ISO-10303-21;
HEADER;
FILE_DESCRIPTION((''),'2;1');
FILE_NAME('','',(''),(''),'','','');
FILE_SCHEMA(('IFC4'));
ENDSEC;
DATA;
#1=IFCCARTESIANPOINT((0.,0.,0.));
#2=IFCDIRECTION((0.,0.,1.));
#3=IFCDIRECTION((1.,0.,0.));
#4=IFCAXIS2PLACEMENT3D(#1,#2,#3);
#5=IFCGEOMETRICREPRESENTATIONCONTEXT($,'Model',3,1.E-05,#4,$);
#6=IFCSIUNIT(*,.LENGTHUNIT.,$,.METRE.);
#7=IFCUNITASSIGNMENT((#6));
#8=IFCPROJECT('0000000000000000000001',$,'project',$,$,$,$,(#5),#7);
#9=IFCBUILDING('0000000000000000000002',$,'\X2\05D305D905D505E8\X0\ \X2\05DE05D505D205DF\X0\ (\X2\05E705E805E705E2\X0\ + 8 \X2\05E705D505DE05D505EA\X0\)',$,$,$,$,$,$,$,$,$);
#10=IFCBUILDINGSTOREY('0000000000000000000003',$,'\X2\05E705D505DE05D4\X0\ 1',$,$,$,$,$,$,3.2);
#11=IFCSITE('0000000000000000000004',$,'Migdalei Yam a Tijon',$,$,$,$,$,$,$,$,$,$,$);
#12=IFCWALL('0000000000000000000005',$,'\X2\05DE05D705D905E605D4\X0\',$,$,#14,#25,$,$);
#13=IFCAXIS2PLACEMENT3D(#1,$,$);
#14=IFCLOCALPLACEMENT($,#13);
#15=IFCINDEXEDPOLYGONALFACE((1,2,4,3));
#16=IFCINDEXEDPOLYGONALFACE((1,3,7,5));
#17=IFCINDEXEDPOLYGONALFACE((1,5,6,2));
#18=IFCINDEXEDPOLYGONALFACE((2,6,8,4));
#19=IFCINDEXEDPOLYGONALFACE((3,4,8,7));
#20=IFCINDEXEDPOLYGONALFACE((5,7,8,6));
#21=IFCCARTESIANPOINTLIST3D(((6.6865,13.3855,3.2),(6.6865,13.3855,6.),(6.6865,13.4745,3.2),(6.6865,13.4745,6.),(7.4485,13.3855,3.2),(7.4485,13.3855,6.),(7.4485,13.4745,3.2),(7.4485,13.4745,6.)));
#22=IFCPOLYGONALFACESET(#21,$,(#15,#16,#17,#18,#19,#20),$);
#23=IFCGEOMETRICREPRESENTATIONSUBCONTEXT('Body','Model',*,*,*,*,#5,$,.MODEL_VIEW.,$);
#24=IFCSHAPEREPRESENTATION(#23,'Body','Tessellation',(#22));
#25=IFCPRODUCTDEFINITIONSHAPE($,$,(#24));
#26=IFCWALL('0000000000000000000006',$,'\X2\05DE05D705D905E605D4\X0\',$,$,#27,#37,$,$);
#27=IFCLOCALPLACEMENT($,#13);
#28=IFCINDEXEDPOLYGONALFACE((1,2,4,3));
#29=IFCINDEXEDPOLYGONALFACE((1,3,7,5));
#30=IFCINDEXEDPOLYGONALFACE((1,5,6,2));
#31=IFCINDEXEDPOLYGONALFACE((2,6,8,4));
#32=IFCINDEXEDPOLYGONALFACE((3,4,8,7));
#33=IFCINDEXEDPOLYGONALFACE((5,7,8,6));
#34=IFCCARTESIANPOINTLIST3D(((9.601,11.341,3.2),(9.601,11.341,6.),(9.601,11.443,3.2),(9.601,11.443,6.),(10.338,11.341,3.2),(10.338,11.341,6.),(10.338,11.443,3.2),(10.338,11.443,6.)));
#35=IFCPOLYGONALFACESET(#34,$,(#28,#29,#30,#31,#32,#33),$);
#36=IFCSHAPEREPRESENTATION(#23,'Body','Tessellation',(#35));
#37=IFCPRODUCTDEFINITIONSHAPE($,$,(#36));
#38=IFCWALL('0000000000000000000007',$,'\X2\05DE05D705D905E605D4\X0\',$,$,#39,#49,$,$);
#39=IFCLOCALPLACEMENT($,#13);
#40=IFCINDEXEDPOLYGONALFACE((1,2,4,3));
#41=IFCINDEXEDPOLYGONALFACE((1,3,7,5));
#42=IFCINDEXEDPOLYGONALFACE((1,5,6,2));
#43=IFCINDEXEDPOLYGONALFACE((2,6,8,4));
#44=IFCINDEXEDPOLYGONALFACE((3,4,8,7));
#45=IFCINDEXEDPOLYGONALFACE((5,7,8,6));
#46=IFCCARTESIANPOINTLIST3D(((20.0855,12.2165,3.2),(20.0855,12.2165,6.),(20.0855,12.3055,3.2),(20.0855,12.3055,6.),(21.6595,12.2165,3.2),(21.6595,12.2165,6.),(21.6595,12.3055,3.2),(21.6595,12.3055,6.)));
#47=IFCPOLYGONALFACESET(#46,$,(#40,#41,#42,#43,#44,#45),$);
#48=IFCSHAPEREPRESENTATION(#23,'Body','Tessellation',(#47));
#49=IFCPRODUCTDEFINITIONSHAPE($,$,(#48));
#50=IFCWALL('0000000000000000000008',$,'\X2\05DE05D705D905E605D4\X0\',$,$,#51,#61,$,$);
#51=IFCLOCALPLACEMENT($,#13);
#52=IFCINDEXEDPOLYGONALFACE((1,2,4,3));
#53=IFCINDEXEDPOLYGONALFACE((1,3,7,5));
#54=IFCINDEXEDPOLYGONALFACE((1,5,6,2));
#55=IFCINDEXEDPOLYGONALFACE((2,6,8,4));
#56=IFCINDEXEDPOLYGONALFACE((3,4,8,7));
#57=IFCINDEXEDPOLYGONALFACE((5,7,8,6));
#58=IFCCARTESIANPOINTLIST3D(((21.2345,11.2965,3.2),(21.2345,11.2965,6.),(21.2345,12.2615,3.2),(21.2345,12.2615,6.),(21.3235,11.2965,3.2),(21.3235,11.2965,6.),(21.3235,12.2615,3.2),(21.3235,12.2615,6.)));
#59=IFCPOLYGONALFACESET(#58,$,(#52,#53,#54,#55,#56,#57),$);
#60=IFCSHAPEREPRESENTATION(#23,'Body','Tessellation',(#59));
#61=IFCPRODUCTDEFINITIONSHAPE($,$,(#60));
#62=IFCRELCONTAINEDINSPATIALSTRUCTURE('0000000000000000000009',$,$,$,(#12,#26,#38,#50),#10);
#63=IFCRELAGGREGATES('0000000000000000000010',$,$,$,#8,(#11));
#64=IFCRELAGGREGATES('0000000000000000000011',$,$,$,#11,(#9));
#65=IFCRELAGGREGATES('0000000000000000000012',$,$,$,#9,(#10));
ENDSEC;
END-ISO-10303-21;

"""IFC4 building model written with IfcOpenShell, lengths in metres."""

from ifc_helpers import new_model, si_unit, frame, origin_with_axes, context, subcontext, project, spatial, line, indexed_curve, outline, extrude, element, save


model = new_model("IFC4")

# Units and contexts
model_context = context("Model", 3, precision=1e-05, world=origin_with_axes())
body_context = subcontext(model_context, "Body", "Model", "MODEL_VIEW")
ifc_project = project(units=[si_unit("LENGTHUNIT", "METRE")], contexts=[model_context])

# Site, building, storey
site = spatial("IfcSite", under=ifc_project, Name="Migdalei Yam a Tijon")
building = spatial("IfcBuilding", under=site, Name="דיור מוגן (קרקע + 8 קומות)")
storey = spatial("IfcBuildingStorey", under=building, Name="קומה 1", Elevation=3.2)

# Walls
element("IfcWall", 1, inside=storey, Name="מחיצה", context=body_context, shape_type="SweptSolid", body=[
    extrude(outline(indexed_curve([(0.0, 0.0), (0.762, 0.0), (0.762, 0.089), (0.0, 0.089)], segments=[line(1, 2, 3, 4, 1)])), frame((6.6865, 13.3855, 3.2), z_axis=(0.0, 0.0, 1.0), x_axis=(1.0, 0.0, 0.0)), (0.0, 0.0, 1.0), 2.8),
])
element("IfcWall", 2, inside=storey, Name="מחיצה", context=body_context, shape_type="SweptSolid", body=[
    extrude(outline(indexed_curve([(0.0, 0.0), (0.737, 0.0), (0.737, 0.102), (0.0, 0.102)], segments=[line(1, 2, 3, 4, 1)])), frame((9.601, 11.341, 3.2), z_axis=(0.0, 0.0, 1.0), x_axis=(1.0, 0.0, 0.0)), (0.0, 0.0, 1.0), 2.8),
])
element("IfcWall", 3, inside=storey, Name="מחיצה", context=body_context, shape_type="SweptSolid", body=[
    extrude(outline(indexed_curve([(0.0, 0.0), (1.574, 0.0), (1.574, 0.089), (0.0, 0.089)], segments=[line(1, 2, 3, 4, 1)])), frame((20.0855, 12.2165, 3.2), z_axis=(0.0, 0.0, 1.0), x_axis=(1.0, 0.0, 0.0)), (0.0, 0.0, 1.0), 2.8),
])
element("IfcWall", 4, inside=storey, Name="מחיצה", context=body_context, shape_type="SweptSolid", body=[
    extrude(outline(indexed_curve([(0.0, 0.0), (0.089, 0.0), (0.089, 0.965), (0.0, 0.965)], segments=[line(1, 2, 3, 4, 1)])), frame((21.2345, 11.2965, 3.2), z_axis=(0.0, 0.0, 1.0), x_axis=(1.0, 0.0, 0.0)), (0.0, 0.0, 1.0), 2.8),
])

save(model, "model.ifc")
